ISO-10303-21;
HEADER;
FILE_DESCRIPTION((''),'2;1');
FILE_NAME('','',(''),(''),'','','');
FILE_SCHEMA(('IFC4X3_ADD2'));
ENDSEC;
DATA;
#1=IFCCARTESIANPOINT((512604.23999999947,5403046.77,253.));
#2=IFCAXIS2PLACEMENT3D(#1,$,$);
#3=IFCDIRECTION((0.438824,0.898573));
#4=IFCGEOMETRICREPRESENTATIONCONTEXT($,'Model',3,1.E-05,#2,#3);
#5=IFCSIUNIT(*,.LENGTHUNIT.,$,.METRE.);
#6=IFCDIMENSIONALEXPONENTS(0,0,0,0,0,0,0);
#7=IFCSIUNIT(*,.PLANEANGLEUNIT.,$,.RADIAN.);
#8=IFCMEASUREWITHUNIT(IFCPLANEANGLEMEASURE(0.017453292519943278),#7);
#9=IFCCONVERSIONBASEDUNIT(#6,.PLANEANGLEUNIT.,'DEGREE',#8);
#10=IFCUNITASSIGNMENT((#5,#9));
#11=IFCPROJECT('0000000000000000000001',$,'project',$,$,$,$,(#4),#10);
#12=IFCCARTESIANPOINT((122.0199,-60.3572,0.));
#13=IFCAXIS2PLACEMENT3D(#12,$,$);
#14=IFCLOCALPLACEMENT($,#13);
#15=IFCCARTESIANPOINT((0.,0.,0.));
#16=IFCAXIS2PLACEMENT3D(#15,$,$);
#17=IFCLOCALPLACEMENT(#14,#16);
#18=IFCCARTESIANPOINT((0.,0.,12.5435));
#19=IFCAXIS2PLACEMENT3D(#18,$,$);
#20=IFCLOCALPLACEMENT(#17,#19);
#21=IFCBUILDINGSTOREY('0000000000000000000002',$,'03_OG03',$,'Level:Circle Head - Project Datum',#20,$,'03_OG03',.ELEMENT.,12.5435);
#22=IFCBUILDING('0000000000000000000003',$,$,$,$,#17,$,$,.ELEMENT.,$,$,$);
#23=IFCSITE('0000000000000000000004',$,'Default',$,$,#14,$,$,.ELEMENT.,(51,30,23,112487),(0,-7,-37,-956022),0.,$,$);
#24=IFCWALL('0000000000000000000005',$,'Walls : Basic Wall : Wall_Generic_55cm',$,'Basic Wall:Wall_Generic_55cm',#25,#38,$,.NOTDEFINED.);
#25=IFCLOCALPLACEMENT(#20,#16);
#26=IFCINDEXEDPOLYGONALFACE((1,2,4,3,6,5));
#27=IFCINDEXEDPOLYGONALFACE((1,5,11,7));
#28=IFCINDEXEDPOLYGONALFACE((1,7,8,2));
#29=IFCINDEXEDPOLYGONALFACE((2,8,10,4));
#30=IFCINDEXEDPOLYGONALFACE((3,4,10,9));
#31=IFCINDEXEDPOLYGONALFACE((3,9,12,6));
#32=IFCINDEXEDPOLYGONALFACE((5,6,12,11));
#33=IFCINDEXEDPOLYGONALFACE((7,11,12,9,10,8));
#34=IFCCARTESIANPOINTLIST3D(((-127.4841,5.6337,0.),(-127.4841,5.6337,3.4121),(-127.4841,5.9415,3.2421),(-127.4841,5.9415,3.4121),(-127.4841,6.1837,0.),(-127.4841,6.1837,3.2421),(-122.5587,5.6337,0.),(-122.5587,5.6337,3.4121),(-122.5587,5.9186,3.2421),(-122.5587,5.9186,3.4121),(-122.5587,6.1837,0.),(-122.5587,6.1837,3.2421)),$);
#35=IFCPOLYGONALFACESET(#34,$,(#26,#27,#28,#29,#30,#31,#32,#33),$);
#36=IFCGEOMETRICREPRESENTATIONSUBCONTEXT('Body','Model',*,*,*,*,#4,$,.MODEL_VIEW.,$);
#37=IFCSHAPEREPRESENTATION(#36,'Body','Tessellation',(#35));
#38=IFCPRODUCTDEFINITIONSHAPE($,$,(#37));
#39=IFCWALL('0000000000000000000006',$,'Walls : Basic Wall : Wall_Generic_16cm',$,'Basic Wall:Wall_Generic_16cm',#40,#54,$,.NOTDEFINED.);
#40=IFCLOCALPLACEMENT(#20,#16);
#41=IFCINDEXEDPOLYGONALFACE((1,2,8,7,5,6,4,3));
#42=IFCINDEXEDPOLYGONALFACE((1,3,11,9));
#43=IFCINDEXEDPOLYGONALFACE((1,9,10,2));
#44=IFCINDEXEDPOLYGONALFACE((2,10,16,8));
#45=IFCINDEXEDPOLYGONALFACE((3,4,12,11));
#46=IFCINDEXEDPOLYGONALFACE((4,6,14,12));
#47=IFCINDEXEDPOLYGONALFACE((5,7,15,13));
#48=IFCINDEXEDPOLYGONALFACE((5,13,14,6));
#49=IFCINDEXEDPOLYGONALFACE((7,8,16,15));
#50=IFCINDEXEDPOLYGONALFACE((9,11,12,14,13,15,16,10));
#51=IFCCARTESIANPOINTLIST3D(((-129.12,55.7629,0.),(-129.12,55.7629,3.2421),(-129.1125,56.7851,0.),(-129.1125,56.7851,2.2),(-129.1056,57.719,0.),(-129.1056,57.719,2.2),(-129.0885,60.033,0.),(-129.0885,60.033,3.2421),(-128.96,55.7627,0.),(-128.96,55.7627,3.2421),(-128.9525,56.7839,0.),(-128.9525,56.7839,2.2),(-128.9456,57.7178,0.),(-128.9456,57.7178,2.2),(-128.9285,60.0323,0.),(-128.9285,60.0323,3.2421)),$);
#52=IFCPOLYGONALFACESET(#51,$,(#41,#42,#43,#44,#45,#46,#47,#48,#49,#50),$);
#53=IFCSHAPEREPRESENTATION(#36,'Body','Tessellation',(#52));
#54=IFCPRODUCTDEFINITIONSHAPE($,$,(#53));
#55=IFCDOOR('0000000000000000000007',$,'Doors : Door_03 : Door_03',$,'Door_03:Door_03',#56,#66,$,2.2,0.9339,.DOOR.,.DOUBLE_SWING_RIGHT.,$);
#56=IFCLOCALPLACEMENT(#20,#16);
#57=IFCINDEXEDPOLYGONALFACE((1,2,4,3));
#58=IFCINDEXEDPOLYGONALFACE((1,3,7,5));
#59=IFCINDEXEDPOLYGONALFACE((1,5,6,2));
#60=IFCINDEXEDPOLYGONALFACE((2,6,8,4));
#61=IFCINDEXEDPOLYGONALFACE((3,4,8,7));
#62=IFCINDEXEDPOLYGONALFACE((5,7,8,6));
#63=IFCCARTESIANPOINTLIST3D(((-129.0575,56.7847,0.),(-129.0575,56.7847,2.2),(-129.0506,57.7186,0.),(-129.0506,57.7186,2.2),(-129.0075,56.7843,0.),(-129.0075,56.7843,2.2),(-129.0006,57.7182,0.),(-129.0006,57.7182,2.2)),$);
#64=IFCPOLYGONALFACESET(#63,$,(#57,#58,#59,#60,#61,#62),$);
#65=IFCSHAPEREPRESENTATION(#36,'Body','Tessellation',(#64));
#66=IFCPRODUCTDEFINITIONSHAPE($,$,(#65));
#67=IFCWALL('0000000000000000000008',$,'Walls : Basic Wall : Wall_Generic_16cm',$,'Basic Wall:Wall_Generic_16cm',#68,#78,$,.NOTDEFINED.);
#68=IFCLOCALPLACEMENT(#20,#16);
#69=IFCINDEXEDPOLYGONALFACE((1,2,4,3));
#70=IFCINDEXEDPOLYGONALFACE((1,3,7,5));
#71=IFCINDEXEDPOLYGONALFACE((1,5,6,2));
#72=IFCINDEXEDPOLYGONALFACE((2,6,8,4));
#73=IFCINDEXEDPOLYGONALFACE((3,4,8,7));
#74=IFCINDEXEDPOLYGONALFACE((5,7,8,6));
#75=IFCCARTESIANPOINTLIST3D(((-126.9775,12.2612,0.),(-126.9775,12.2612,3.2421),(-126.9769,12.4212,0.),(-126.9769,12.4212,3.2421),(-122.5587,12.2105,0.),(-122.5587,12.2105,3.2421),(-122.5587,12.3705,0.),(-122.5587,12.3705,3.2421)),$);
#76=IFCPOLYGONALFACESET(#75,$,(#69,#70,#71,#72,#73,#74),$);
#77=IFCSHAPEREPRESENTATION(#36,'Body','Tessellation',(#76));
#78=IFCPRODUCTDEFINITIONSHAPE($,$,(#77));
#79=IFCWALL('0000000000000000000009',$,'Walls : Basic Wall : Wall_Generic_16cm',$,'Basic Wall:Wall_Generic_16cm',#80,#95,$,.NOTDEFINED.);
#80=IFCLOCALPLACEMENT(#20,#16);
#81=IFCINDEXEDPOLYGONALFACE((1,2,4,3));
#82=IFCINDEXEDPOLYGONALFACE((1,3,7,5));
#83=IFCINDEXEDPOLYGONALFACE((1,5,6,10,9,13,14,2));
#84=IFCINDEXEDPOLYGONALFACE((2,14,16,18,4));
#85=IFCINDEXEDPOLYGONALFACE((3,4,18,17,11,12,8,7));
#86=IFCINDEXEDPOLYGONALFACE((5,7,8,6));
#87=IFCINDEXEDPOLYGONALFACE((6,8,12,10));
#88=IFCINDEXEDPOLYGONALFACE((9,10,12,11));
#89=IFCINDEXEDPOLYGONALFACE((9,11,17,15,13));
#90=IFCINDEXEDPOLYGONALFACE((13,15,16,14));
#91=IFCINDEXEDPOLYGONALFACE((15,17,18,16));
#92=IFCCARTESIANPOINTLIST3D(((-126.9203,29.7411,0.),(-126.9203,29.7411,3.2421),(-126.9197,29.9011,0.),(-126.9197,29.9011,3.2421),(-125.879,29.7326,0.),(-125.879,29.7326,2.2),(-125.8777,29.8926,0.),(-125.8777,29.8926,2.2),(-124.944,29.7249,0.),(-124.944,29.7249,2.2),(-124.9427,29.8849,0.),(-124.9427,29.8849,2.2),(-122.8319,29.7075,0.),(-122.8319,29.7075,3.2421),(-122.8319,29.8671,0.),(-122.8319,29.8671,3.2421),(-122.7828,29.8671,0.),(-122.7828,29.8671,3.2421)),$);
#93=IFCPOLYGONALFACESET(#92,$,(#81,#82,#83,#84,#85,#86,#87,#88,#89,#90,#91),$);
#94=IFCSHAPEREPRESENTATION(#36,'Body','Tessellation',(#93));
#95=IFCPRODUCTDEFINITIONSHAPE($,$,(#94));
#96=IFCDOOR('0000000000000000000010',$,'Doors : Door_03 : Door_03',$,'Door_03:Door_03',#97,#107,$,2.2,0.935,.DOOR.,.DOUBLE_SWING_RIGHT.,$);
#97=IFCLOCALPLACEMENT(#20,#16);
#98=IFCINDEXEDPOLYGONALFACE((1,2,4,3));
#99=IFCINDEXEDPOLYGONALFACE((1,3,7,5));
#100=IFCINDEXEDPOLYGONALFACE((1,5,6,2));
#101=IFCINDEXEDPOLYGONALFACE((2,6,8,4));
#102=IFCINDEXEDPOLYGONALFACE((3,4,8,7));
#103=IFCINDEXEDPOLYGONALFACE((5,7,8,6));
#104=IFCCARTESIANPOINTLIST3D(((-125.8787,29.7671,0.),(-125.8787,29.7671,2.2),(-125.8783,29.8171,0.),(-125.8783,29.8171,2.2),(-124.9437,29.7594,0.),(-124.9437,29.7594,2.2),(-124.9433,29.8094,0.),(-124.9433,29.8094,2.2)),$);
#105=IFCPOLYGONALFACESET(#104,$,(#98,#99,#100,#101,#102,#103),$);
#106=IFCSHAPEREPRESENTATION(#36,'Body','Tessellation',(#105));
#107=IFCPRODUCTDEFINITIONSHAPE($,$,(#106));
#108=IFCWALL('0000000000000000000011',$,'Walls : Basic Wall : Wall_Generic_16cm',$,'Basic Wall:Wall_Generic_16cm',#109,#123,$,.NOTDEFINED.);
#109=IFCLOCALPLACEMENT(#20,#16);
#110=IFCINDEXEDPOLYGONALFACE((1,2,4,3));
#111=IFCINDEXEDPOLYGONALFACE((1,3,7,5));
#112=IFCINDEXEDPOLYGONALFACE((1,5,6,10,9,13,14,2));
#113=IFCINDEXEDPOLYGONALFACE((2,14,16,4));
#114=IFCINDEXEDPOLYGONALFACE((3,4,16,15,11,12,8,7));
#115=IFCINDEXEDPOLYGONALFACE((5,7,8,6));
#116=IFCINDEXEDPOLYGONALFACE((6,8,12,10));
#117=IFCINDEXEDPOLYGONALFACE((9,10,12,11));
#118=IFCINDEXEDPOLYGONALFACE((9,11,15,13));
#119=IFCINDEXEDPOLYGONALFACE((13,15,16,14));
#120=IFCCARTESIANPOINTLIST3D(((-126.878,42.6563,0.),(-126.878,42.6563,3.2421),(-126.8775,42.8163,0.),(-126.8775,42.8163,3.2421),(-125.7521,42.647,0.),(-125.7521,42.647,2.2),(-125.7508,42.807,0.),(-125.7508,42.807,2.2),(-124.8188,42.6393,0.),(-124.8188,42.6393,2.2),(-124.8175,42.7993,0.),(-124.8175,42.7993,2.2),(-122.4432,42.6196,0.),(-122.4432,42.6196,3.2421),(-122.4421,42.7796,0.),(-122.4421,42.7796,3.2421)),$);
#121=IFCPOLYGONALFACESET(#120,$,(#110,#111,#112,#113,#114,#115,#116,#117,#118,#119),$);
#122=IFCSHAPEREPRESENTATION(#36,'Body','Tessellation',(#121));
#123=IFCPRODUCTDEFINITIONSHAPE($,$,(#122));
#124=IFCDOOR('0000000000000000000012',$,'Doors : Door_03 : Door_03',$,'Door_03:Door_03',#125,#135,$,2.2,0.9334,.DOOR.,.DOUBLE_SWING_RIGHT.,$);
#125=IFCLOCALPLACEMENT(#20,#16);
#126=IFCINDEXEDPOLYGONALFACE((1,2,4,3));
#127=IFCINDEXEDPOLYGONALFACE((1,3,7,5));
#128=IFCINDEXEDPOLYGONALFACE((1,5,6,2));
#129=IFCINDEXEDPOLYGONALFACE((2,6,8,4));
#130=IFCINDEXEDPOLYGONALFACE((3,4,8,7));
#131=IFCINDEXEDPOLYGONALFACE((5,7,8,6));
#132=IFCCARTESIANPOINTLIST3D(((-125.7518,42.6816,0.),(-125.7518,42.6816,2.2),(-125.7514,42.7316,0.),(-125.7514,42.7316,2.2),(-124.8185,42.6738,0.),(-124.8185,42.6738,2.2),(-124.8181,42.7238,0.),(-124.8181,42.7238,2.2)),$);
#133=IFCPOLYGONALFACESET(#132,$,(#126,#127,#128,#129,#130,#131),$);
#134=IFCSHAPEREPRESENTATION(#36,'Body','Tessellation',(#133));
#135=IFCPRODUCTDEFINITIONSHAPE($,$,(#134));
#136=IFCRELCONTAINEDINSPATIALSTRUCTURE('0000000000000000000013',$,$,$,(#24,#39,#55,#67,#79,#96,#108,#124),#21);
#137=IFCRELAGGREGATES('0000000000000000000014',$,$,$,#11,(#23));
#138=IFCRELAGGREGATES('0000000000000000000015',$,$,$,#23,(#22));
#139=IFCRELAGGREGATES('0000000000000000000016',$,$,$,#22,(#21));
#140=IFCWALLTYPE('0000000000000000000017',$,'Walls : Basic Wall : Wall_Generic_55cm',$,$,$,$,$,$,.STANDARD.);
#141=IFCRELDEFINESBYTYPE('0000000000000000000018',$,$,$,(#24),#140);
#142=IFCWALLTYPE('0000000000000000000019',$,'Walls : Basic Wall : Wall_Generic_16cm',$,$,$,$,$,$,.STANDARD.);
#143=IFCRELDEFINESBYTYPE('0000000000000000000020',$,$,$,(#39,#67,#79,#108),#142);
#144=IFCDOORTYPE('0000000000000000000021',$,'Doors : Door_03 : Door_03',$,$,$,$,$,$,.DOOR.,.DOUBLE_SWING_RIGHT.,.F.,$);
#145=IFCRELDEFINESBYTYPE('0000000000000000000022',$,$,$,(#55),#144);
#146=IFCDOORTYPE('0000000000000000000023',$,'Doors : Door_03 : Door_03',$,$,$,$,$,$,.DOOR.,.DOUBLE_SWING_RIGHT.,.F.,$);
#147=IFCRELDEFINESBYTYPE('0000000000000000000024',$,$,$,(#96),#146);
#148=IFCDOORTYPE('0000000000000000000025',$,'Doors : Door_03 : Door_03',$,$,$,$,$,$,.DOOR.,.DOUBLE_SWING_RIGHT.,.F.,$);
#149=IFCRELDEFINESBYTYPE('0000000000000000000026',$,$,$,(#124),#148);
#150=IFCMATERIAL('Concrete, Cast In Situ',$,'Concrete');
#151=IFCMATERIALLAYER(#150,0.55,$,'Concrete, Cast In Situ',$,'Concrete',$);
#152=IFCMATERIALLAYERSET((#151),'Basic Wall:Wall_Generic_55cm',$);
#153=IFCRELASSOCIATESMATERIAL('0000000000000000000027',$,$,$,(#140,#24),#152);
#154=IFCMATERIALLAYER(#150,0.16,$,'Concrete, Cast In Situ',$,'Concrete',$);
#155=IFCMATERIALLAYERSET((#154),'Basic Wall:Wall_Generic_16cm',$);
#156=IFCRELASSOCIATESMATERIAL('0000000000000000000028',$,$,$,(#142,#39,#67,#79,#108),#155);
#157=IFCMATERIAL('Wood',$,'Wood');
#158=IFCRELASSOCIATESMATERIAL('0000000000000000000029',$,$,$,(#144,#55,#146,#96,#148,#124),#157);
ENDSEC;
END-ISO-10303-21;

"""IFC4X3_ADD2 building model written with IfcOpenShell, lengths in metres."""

from ifc_helpers import new_model, entity, si_unit, converted_unit, direction, frame, frame_2d, origin, origin_2d_with_axis, place, context, subcontext, project, spatial, polyline, rectangle, outline, extrude, clip, bounded_halfspace, source, transform, mapped, material, layer, layer_set, type_object, type_shapes, element, fill, save


model = new_model("IFC4X3_ADD2")

# Units and contexts
model_context = context("Model", 3, precision=1e-05, world=frame((512604.23999999947, 5403046.77, 253.0)), true_north=direction((0.438824, 0.898573)))
body_context = subcontext(model_context, "Body", "Model", "MODEL_VIEW")
ifc_project = project(units=[si_unit("LENGTHUNIT", "METRE"), converted_unit("PLANEANGLEUNIT", "DEGREE", entity("IfcPlaneAngleMeasure", 0.017453292519943278), si_unit("PLANEANGLEUNIT", "RADIAN"), dimensions=[0, 0, 0, 0, 0, 0, 0])], contexts=[model_context])

# Site, building, storey
site_placement = place(None, frame((122.0199, -60.3572, 0.0)))
site = spatial("IfcSite", under=ifc_project, at=site_placement, Name="Default", CompositionType="ELEMENT", RefLatitude=(51, 30, 23, 112487), RefLongitude=(0, -7, -37, -956022), RefElevation=0.0)
building_placement = place(site_placement, origin())
building = spatial("IfcBuilding", under=site, at=building_placement, CompositionType="ELEMENT")
storey_placement = place(building_placement, frame((0.0, 0.0, 12.5435)))
storey = spatial("IfcBuildingStorey", under=building, at=storey_placement, Name="03_OG03", ObjectType="Level:Circle Head - Project Datum", LongName="03_OG03", CompositionType="ELEMENT", Elevation=12.5435)

# Wall
ifc_material_1 = material(Name="Concrete, Cast In Situ", Category="Concrete")
ifc_layer_1 = layer(ifc_material_1, 0.55, Name="Concrete, Cast In Situ", Category="Concrete")
ifc_layer_set_1 = layer_set([ifc_layer_1], Name="Basic Wall:Wall_Generic_55cm")
wall_type_1 = type_object("IfcWallType", Name="Walls : Basic Wall : Wall_Generic_55cm", PredefinedType="STANDARD", material=ifc_layer_set_1)
wall_1_placement = place(storey_placement, frame((-127.4841, 5.9087, 0.0)))
element("IfcWall", 1, at=wall_1_placement, inside=storey, type_object=wall_type_1, material=ifc_layer_set_1, Name="Walls : Basic Wall : Wall_Generic_55cm", ObjectType="Basic Wall:Wall_Generic_55cm", PredefinedType="NOTDEFINED", context=body_context, shape_type="Clipping", body=[
    clip(extrude(outline(polyline([(4.9254, -0.275), (4.9254, 0.275), (0.4534, 0.275), (0.1934, 0.275), (0.0, 0.275), (0.0, -0.275), (4.9254, -0.275)])), origin(), (0.0, 0.0, 1.0), 3.4121), bounded_halfspace(frame((4.9254, 0.0099, 3.2421), z_axis=(0.0, 0.0, -1.0), x_axis=(-0.002837, -0.999996, 0.0)), True, frame((4.9254, 0.0099, 3.2421)), polyline([(0.0, 0.0), (0.0, 0.2651), (-4.4719, 0.2651), (-4.7319, 0.2651), (-4.9254, 0.2651), (-4.9254, 0.0229), (0.0, 0.0)]))),
])

# Wall, opening, door
ifc_layer_2 = layer(ifc_material_1, 0.16, Name="Concrete, Cast In Situ", Category="Concrete")
ifc_layer_set_2 = layer_set([ifc_layer_2], Name="Basic Wall:Wall_Generic_16cm")
wall_type_2 = type_object("IfcWallType", Name="Walls : Basic Wall : Wall_Generic_16cm", PredefinedType="STANDARD", material=ifc_layer_set_2)
wall_2_placement = place(storey_placement, frame((-129.0085, 60.0329, 0.0), z_axis=(0.0, 0.0, 1.0), x_axis=(-0.007379, -0.999973, 0.0)))
wall_2 = element("IfcWall", 2, at=wall_2_placement, inside=storey, type_object=wall_type_2, material=ifc_layer_set_2, Name="Walls : Basic Wall : Wall_Generic_16cm", ObjectType="Basic Wall:Wall_Generic_16cm", PredefinedType="NOTDEFINED", context=body_context, shape_type="Clipping", body=[
    clip(extrude(outline(polyline([(0.0005, -0.08), (4.2707, -0.08), (4.2697, 0.08), (0.0, 0.08), (0.0005, -0.08)])), origin(), (0.0, 0.0, 1.0), 3.2421), bounded_halfspace(frame((0.0005, -0.08, 3.2421), z_axis=(0.0, 0.0, -1.0), x_axis=(0.99999, 0.004541, 0.0)), True, frame((0.0005, -0.08, 3.2421)), polyline([(0.0, 0.0), (4.2702, 0.0), (4.2692, 0.16), (-0.0005, 0.16), (0.0, 0.0)]))),
])
opening_1_placement = place(wall_2_placement, frame((59.0793, 129.448, 0.0), z_axis=(0.0, 0.0, 1.0), x_axis=(-0.007379, 0.999973, 0.0)))
opening_1 = element("IfcOpeningElement", 3, at=opening_1_placement, cuts=wall_2, PredefinedType="OPENING", context=body_context, shape_type="SweptSolid", body=[
    extrude(rectangle(XDim=2.2, YDim=0.9339, at=frame_2d((0.0, 0.0), x_axis=(0.0, 1.0))), frame((-129.109, 57.2521, 1.1), z_axis=(0.999973, -0.007379, 0.0), x_axis=(-0.007379, -0.999973, 0.0)), (0.0, 0.0, 1.0), 0.16),
])
ifc_material_2 = material(Name="Wood", Category="Wood")
door_type_1 = type_object("IfcDoorType", Name="Doors : Door_03 : Door_03", OperationType="DOUBLE_SWING_RIGHT", ParameterTakesPrecedence=False, PredefinedType="DOOR", material=ifc_material_2)
shared_shape_1 = source(origin(), body_context, "Body", "SweptSolid", [
    extrude(rectangle(XDim=0.05, YDim=0.9339, at=origin_2d_with_axis()), frame((0.4669, 0.08, 0.0), z_axis=(0.0, 0.0, 1.0), x_axis=(0.0, 1.0, 0.0)), (0.0, 0.0, 1.0), 2.2),
])
type_shapes(door_type_1, [shared_shape_1])
door_1_placement = place(opening_1_placement, frame((-128.9525, 56.7839, 0.0), z_axis=(0.0, 0.0, 1.0), x_axis=(0.007379, 0.999973, 0.0)))
door_1 = element("IfcDoor", 4, at=door_1_placement, inside=storey, type_object=door_type_1, material=ifc_material_2, Name="Doors : Door_03 : Door_03", ObjectType="Door_03:Door_03", OperationType="DOUBLE_SWING_RIGHT", OverallHeight=2.2, OverallWidth=0.9339, PredefinedType="DOOR", context=body_context, shape_type="MappedRepresentation", body=[
    mapped(shared_shape_1, transform((0.0, 0.0, 0.0), scale=1.0)),
])
fill(opening_1, door_1)

# Wall
wall_3_placement = place(storey_placement, frame((-126.9778, 12.3412, 0.0), z_axis=(0.0, 0.0, 1.0), x_axis=(0.999934, -0.011463, 0.0)))
element("IfcWall", 5, at=wall_3_placement, inside=storey, type_object=wall_type_2, material=ifc_layer_set_2, Name="Walls : Basic Wall : Wall_Generic_16cm", ObjectType="Basic Wall:Wall_Generic_16cm", PredefinedType="NOTDEFINED", context=body_context, shape_type="Clipping", body=[
    clip(extrude(outline(polyline([(4.4204, -0.08), (4.4185, 0.08), (0.0, 0.08), (0.0013, -0.08), (1.7145, -0.08), (1.8545, -0.08), (4.4204, -0.08)])), origin(), (0.0, 0.0, 1.0), 3.2421), bounded_halfspace(frame((0.0013, -0.08, 3.2421), z_axis=(0.0, 0.0, -1.0), x_axis=(0.008626, -0.999963, 0.0)), True, frame((0.0013, -0.08, 3.2421)), polyline([(0.0, 0.0), (1.7132, 0.0), (1.8532, 0.0), (4.4191, 0.0), (4.4172, 0.16), (-0.0013, 0.16), (0.0, 0.0)]))),
])

# Walls, openings, doors
wall_4_placement = place(storey_placement, frame((-126.9204, 29.8211, 0.0), z_axis=(0.0, 0.0, 1.0), x_axis=(0.999966, -0.008217, 0.0)))
wall_4 = element("IfcWall", 6, at=wall_4_placement, inside=storey, type_object=wall_type_2, material=ifc_layer_set_2, Name="Walls : Basic Wall : Wall_Generic_16cm", ObjectType="Basic Wall:Wall_Generic_16cm", PredefinedType="NOTDEFINED", context=body_context, shape_type="Clipping", body=[
    clip(clip(clip(extrude(outline(polyline([(4.1371, 0.08), (0.0, 0.08), (0.0008, -0.08), (4.0893, -0.08), (4.0879, 0.0796), (4.1371, 0.08)])), origin(), (0.0, 0.0, 1.0), 3.2421), bounded_halfspace(frame((4.0879, 0.08, 3.2421), z_axis=(0.0, 0.0, -1.0), x_axis=(0.005379, -0.999986, 0.0)), True, frame((4.0879, 0.08, 3.2421)), polyline([(0.0, 0.0), (-4.0879, 0.0), (-4.0871, -0.16), (0.0013, -0.16), (0.0, 0.0)]))), bounded_halfspace(frame((4.0879, 0.0796, 3.2421), z_axis=(-0.008217, 0.999966, 0.0), x_axis=(-0.999966, -0.008217, 0.0)), True, frame((4.0879, 0.0796, 3.2421), z_axis=(-0.008217, 0.999966, 0.0), x_axis=(-0.999966, -0.008217, 0.0)), polyline([(0.0, 0.0), (-0.0492, 0.0), (-0.0492, -3.2421), (0.0, -3.2421), (0.0, 0.0)]))), bounded_halfspace(frame((4.0879, 0.0796, 0.0), z_axis=(-0.999966, -0.008217, 0.0), x_axis=(-0.008217, 0.999966, 0.0)), True, frame((4.0879, 0.0796, 0.0), z_axis=(-0.999966, -0.008217, 0.0), x_axis=(-0.008217, 0.999966, 0.0)), polyline([(0.0, 0.0), (-0.1596, 0.0), (-0.1596, -3.2421), (0.0, -3.2421), (0.0, 0.0)]))),
])
opening_2_placement = place(wall_4_placement, frame((127.1611, -28.7772, 0.0), z_axis=(0.0, 0.0, 1.0), x_axis=(0.999966, 0.008217, 0.0)))
opening_2 = element("IfcOpeningElement", 7, at=opening_2_placement, cuts=wall_4, PredefinedType="OPENING", context=body_context, shape_type="SweptSolid", body=[
    extrude(rectangle(XDim=2.2, YDim=0.935, at=frame_2d((0.0, 0.0), x_axis=(0.0, 1.0))), frame((-125.4115, 29.7287, 1.1), z_axis=(0.008217, 0.999966, 0.0), x_axis=(0.999966, -0.008217, 0.0)), (0.0, 0.0, 1.0), 0.16),
])
door_type_2 = type_object("IfcDoorType", Name="Doors : Door_03 : Door_03", OperationType="DOUBLE_SWING_RIGHT", ParameterTakesPrecedence=False, PredefinedType="DOOR", material=ifc_material_2)
shared_shape_2 = source(origin(), body_context, "Body", "SweptSolid", [
    extrude(rectangle(XDim=0.05, YDim=0.935, at=origin_2d_with_axis()), frame((0.4675, 0.1004, 0.0), z_axis=(0.0, 0.0, 1.0), x_axis=(0.0, 1.0, 0.0)), (0.0, 0.0, 1.0), 2.2),
])
type_shapes(door_type_2, [shared_shape_2])
door_2_placement = place(opening_2_placement, frame((-124.9427, 29.8849, 0.0), z_axis=(0.0, 0.0, 1.0), x_axis=(-0.999966, 0.008217, 0.0)))
door_2 = element("IfcDoor", 8, at=door_2_placement, inside=storey, type_object=door_type_2, material=ifc_material_2, Name="Doors : Door_03 : Door_03", ObjectType="Door_03:Door_03", OperationType="DOUBLE_SWING_RIGHT", OverallHeight=2.2, OverallWidth=0.935, PredefinedType="DOOR", context=body_context, shape_type="MappedRepresentation", body=[
    mapped(shared_shape_2, transform((0.0, 0.0, 0.0), scale=1.0)),
])
fill(opening_2, door_2)
wall_5_placement = place(storey_placement, frame((-126.8782, 42.7363, 0.0), z_axis=(0.0, 0.0, 1.0), x_axis=(0.999966, -0.008285, 0.0)))
wall_5 = element("IfcWall", 9, at=wall_5_placement, inside=storey, type_object=wall_type_2, material=ifc_layer_set_2, Name="Walls : Basic Wall : Wall_Generic_16cm", ObjectType="Basic Wall:Wall_Generic_16cm", PredefinedType="NOTDEFINED", context=body_context, shape_type="Clipping", body=[
    clip(extrude(outline(polyline([(0.0008, -0.08), (4.4358, -0.08), (4.4355, 0.08), (0.0, 0.08), (0.0008, -0.08)])), origin(), (0.0, 0.0, 1.0), 3.2421), bounded_halfspace(frame((0.0008, -0.08, 3.2421), z_axis=(0.0, 0.0, -1.0), x_axis=(0.005448, -0.999985, 0.0)), True, frame((0.0008, -0.08, 3.2421)), polyline([(0.0, 0.0), (4.435, 0.0), (4.4347, 0.16), (-0.0008, 0.16), (0.0, 0.0)]))),
])
opening_3_placement = place(wall_5_placement, frame((127.2279, -41.6836, 0.0), z_axis=(0.0, 0.0, 1.0), x_axis=(0.999966, 0.008285, 0.0)))
opening_3 = element("IfcOpeningElement", 10, at=opening_3_placement, cuts=wall_5, PredefinedType="OPENING", context=body_context, shape_type="SweptSolid", body=[
    extrude(rectangle(XDim=2.2, YDim=0.9334, at=frame_2d((0.0, 0.0), x_axis=(0.0, 1.0))), frame((-125.2855, 42.6431, 1.1), z_axis=(0.008285, 0.999966, 0.0), x_axis=(0.999966, -0.008285, 0.0)), (0.0, 0.0, 1.0), 0.16),
])
door_type_3 = type_object("IfcDoorType", Name="Doors : Door_03 : Door_03", OperationType="DOUBLE_SWING_RIGHT", ParameterTakesPrecedence=False, PredefinedType="DOOR", material=ifc_material_2)
shared_shape_3 = source(origin(), body_context, "Body", "SweptSolid", [
    extrude(rectangle(XDim=0.05, YDim=0.9334, at=origin_2d_with_axis()), frame((0.4667, 0.1004, 0.0), z_axis=(0.0, 0.0, 1.0), x_axis=(0.0, 1.0, 0.0)), (0.0, 0.0, 1.0), 2.2),
])
type_shapes(door_type_3, [shared_shape_3])
door_3_placement = place(opening_3_placement, frame((-124.8175, 42.7993, 0.0), z_axis=(0.0, 0.0, 1.0), x_axis=(-0.999966, 0.008285, 0.0)))
door_3 = element("IfcDoor", 11, at=door_3_placement, inside=storey, type_object=door_type_3, material=ifc_material_2, Name="Doors : Door_03 : Door_03", ObjectType="Door_03:Door_03", OperationType="DOUBLE_SWING_RIGHT", OverallHeight=2.2, OverallWidth=0.9334, PredefinedType="DOOR", context=body_context, shape_type="MappedRepresentation", body=[
    mapped(shared_shape_3, transform((0.0, 0.0, 0.0), scale=1.0)),
])
fill(opening_3, door_3)

save(model, "model.ifc")
